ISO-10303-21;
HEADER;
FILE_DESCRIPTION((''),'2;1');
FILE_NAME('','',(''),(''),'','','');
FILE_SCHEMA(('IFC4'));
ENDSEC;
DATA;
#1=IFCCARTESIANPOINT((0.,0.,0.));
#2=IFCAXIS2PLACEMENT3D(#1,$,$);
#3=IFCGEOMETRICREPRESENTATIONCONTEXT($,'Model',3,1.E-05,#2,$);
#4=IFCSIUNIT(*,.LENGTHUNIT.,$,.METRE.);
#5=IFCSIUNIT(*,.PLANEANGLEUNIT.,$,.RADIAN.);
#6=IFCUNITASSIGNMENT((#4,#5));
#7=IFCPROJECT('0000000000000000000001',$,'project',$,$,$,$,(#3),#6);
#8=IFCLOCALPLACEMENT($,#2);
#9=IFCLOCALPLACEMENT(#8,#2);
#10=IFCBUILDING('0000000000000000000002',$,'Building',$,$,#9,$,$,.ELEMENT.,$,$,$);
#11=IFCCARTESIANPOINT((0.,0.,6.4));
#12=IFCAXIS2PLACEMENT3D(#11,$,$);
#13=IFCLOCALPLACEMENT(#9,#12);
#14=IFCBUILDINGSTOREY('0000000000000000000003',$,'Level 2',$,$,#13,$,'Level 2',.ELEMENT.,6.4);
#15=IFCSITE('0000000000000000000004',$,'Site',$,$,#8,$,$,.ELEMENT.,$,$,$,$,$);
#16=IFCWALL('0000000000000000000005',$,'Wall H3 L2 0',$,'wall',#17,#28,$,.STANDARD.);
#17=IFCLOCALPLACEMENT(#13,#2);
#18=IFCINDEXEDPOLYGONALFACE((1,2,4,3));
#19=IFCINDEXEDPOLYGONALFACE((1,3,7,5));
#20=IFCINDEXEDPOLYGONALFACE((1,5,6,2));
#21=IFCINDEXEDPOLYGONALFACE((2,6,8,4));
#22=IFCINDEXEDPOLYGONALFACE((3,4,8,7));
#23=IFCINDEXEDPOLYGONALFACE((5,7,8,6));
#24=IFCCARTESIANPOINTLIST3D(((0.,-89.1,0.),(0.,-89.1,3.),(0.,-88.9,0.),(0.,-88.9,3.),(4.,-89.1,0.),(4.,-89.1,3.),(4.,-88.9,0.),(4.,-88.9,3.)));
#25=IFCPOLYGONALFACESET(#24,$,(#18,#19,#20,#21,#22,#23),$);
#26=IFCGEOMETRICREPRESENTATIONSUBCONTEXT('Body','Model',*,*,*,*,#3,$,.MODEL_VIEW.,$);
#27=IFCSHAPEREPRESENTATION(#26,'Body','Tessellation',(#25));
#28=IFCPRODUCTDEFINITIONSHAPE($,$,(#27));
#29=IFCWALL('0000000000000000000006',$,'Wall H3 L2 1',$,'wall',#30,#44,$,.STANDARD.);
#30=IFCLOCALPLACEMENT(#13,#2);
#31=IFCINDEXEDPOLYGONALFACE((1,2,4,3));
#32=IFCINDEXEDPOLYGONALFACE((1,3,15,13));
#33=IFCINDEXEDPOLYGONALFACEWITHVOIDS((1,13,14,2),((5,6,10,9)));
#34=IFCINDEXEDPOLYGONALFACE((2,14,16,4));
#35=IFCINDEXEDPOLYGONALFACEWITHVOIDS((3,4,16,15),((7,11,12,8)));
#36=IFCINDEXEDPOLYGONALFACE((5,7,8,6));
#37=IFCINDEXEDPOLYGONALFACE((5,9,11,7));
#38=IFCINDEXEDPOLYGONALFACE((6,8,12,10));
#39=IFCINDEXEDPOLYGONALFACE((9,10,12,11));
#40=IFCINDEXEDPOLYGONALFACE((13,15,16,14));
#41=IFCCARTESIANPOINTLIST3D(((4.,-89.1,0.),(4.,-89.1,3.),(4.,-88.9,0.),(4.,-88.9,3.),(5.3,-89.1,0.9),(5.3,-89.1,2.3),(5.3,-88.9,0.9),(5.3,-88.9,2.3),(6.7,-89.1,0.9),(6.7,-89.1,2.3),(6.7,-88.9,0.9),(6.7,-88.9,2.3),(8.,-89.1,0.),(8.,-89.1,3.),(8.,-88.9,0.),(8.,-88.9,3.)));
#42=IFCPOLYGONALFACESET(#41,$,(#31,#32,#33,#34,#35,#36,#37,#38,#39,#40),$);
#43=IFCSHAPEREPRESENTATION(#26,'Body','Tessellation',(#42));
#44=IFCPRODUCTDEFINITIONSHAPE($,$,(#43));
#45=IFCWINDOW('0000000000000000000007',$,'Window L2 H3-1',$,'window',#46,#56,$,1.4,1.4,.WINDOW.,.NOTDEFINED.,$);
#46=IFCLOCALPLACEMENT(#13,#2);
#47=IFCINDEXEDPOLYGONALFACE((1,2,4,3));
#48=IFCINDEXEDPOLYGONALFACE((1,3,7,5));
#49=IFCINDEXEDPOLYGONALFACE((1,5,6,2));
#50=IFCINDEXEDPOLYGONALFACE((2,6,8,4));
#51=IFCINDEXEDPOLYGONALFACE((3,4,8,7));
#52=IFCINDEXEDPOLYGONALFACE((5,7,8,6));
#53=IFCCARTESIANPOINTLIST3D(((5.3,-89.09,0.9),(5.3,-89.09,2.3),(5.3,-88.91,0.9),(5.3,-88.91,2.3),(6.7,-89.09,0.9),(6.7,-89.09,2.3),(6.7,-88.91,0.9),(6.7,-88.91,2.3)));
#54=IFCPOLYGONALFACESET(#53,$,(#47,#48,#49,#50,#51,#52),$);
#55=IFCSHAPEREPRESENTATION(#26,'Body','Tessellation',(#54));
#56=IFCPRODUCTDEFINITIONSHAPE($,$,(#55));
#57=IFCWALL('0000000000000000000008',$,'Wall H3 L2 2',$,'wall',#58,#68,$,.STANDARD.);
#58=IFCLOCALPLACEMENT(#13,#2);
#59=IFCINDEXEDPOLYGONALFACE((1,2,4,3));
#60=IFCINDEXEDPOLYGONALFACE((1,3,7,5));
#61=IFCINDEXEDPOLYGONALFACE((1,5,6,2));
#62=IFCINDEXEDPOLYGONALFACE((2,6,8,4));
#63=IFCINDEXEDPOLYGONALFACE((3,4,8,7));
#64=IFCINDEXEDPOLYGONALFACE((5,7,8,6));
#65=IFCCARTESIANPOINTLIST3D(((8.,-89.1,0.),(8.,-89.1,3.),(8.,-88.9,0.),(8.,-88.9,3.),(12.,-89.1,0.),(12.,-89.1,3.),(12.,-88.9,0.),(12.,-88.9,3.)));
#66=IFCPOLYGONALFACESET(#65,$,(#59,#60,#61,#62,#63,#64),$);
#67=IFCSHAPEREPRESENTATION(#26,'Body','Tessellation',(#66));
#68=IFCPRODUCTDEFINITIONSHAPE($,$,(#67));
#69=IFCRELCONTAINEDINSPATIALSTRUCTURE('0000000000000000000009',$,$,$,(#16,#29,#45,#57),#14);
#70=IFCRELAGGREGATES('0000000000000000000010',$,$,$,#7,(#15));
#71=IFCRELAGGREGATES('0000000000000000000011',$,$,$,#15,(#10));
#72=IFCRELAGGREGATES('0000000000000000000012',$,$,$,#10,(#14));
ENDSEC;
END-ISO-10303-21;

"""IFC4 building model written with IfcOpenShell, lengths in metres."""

from ifc_helpers import new_model, si_unit, frame, frame_2d, origin, origin_2d, place, context, subcontext, project, spatial, rectangle, extrude, element, fill, save


model = new_model("IFC4")

# Units and contexts
model_context = context("Model", 3, precision=1e-05, world=origin())
body_context = subcontext(model_context, "Body", "Model", "MODEL_VIEW")
ifc_project = project(units=[si_unit("LENGTHUNIT", "METRE"), si_unit("PLANEANGLEUNIT", "RADIAN")], contexts=[model_context])

# Site, building, storey
site_placement = place(None, origin())
site = spatial("IfcSite", under=ifc_project, at=site_placement, Name="Site", CompositionType="ELEMENT")
building_placement = place(site_placement, origin())
building = spatial("IfcBuilding", under=site, at=building_placement, Name="Building", CompositionType="ELEMENT")
storey_placement = place(building_placement, frame((0.0, 0.0, 6.4)))
storey = spatial("IfcBuildingStorey", under=building, at=storey_placement, Name="Level 2", LongName="Level 2", CompositionType="ELEMENT", Elevation=6.4)

# Wall
for number, where, z_axis, x_axis, name in (
    (1, (0.0, -89.0, 0.0), (0.0, 0.0, 1.0), (1.0, 0.0, 0.0), "Wall H3 L2 0"),
):
    element("IfcWall", number, at=place(storey_placement, frame(where, z_axis=z_axis, x_axis=x_axis)), inside=storey, Name=name, ObjectType="wall", PredefinedType="STANDARD", context=body_context, shape_type="SweptSolid", body=[
        extrude(rectangle(XDim=4.0, YDim=0.2, at=frame_2d((2.0, 0.0))), origin(), (0.0, 0.0, 1.0), 3.0),
    ])

# Wall, opening, window
wall_1_placement = place(storey_placement, frame((4.0, -89.0, 0.0), z_axis=(0.0, 0.0, 1.0), x_axis=(1.0, 0.0, 0.0)))
wall_1 = element("IfcWall", 2, at=wall_1_placement, inside=storey, Name="Wall H3 L2 1", ObjectType="wall", PredefinedType="STANDARD", context=body_context, shape_type="SweptSolid", body=[
    extrude(rectangle(XDim=4.0, YDim=0.2, at=frame_2d((2.0, 0.0))), origin(), (0.0, 0.0, 1.0), 3.0),
])
opening_1_placement = place(storey_placement, frame((6.0, -89.0, 0.9), z_axis=(0.0, 0.0, 1.0), x_axis=(1.0, 0.0, 0.0)))
opening_1 = element("IfcOpeningElement", 3, at=opening_1_placement, cuts=wall_1, ObjectType="Opening", PredefinedType="OPENING", context=body_context, shape_type="SweptSolid", body=[
    extrude(rectangle(XDim=1.4, YDim=0.22, at=origin_2d()), origin(), (0.0, 0.0, 1.0), 1.4),
])
window_1_placement = place(storey_placement, frame((6.0, -89.0, 0.9), z_axis=(0.0, 0.0, 1.0), x_axis=(1.0, 0.0, 0.0)))
window_1 = element("IfcWindow", 4, at=window_1_placement, inside=storey, Name="Window L2 H3-1", ObjectType="window", OverallHeight=1.4, OverallWidth=1.4, PartitioningType="NOTDEFINED", PredefinedType="WINDOW", context=body_context, shape_type="SweptSolid", body=[
    extrude(rectangle(XDim=1.4, YDim=0.18, at=origin_2d()), origin(), (0.0, 0.0, 1.0), 1.4),
])
fill(opening_1, window_1)

# Wall
wall_2_placement = place(storey_placement, frame((8.0, -89.0, 0.0), z_axis=(0.0, 0.0, 1.0), x_axis=(1.0, 0.0, 0.0)))
element("IfcWall", 5, at=wall_2_placement, inside=storey, Name="Wall H3 L2 2", ObjectType="wall", PredefinedType="STANDARD", context=body_context, shape_type="SweptSolid", body=[
    extrude(rectangle(XDim=4.0, YDim=0.2, at=frame_2d((2.0, 0.0))), origin(), (0.0, 0.0, 1.0), 3.0),
])

save(model, "model.ifc")
